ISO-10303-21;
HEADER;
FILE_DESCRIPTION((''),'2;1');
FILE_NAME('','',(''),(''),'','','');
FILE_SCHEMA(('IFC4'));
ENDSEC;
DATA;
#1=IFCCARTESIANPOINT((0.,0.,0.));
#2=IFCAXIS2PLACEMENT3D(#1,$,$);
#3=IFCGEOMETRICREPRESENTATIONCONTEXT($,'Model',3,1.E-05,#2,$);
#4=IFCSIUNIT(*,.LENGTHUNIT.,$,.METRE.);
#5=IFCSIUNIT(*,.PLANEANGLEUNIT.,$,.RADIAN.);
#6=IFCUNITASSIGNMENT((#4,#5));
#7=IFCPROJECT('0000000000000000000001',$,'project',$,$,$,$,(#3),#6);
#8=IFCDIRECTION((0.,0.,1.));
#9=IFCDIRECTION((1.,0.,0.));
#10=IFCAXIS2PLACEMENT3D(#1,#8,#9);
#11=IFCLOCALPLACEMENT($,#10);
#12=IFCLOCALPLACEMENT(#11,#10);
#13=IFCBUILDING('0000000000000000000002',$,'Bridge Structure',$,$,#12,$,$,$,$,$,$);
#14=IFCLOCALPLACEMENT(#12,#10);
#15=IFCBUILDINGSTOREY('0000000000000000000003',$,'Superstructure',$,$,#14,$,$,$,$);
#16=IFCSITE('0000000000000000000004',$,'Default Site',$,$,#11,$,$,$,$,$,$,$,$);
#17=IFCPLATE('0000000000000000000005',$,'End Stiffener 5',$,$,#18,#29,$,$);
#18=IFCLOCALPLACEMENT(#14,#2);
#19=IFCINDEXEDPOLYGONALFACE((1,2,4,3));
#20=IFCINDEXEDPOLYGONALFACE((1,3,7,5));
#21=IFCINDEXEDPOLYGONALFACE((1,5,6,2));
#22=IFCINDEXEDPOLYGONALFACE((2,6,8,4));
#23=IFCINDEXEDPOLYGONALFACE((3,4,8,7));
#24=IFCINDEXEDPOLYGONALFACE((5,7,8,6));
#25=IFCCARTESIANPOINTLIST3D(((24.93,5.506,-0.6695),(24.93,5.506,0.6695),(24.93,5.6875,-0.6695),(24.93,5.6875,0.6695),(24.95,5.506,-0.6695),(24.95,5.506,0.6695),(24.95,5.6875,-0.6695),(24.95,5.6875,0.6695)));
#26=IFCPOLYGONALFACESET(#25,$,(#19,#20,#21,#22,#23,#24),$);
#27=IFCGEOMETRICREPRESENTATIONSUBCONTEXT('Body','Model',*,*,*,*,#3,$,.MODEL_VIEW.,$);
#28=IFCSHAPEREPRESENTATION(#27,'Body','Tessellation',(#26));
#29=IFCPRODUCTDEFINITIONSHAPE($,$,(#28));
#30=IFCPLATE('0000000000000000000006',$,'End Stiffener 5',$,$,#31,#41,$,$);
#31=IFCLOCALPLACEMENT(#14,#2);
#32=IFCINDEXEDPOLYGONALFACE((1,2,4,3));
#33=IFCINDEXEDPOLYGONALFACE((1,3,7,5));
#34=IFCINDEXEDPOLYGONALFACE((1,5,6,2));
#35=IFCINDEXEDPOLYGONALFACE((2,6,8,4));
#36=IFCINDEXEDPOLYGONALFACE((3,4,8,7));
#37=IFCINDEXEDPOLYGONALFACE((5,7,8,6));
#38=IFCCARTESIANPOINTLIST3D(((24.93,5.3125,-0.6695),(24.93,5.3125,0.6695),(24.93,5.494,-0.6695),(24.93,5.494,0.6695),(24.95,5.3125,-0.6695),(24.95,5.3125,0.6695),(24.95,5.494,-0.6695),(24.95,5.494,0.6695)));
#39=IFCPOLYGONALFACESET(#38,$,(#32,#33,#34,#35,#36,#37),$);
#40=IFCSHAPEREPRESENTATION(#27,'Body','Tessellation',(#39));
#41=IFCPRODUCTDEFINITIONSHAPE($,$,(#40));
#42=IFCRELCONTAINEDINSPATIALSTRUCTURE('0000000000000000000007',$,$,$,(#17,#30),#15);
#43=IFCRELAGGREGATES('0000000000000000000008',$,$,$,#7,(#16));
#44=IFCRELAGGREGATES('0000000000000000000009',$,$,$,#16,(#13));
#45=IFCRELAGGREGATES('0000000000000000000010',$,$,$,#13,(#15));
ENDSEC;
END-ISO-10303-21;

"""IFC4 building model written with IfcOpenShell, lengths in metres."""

from ifc_helpers import new_model, si_unit, frame, origin, origin_with_axes, origin_2d_with_axis, place, context, subcontext, project, spatial, rectangle, extrude, element, save


model = new_model("IFC4")

# Units and contexts
model_context = context("Model", 3, precision=1e-05, world=origin())
body_context = subcontext(model_context, "Body", "Model", "MODEL_VIEW")
ifc_project = project(units=[si_unit("LENGTHUNIT", "METRE"), si_unit("PLANEANGLEUNIT", "RADIAN")], contexts=[model_context])

# Site, building, storey
site_placement = place(None, origin_with_axes())
site = spatial("IfcSite", under=ifc_project, at=site_placement, Name="Default Site")
building_placement = place(site_placement, origin_with_axes())
building = spatial("IfcBuilding", under=site, at=building_placement, Name="Bridge Structure")
storey_placement = place(building_placement, origin_with_axes())
storey = spatial("IfcBuildingStorey", under=building, at=storey_placement, Name="Superstructure")

# Plates
for number, where, z_axis, x_axis, name in (
    (1, (24.94, 5.5968, -0.6695), (0.0, 0.0, 1.0), (1.0, 0.0, 0.0), "End Stiffener 5"),
    (2, (24.94, 5.4032, -0.6695), (0.0, 0.0, 1.0), (1.0, 0.0, 0.0), "End Stiffener 5"),
):
    element("IfcPlate", number, at=place(storey_placement, frame(where, z_axis=z_axis, x_axis=x_axis)), inside=storey, Name=name, context=body_context, shape_type="SweptSolid", body=[
        extrude(rectangle(XDim=0.02, YDim=0.1815, at=origin_2d_with_axis()), origin_with_axes(), (0.0, 0.0, 1.0), 1.339),
    ])

save(model, "model.ifc")
